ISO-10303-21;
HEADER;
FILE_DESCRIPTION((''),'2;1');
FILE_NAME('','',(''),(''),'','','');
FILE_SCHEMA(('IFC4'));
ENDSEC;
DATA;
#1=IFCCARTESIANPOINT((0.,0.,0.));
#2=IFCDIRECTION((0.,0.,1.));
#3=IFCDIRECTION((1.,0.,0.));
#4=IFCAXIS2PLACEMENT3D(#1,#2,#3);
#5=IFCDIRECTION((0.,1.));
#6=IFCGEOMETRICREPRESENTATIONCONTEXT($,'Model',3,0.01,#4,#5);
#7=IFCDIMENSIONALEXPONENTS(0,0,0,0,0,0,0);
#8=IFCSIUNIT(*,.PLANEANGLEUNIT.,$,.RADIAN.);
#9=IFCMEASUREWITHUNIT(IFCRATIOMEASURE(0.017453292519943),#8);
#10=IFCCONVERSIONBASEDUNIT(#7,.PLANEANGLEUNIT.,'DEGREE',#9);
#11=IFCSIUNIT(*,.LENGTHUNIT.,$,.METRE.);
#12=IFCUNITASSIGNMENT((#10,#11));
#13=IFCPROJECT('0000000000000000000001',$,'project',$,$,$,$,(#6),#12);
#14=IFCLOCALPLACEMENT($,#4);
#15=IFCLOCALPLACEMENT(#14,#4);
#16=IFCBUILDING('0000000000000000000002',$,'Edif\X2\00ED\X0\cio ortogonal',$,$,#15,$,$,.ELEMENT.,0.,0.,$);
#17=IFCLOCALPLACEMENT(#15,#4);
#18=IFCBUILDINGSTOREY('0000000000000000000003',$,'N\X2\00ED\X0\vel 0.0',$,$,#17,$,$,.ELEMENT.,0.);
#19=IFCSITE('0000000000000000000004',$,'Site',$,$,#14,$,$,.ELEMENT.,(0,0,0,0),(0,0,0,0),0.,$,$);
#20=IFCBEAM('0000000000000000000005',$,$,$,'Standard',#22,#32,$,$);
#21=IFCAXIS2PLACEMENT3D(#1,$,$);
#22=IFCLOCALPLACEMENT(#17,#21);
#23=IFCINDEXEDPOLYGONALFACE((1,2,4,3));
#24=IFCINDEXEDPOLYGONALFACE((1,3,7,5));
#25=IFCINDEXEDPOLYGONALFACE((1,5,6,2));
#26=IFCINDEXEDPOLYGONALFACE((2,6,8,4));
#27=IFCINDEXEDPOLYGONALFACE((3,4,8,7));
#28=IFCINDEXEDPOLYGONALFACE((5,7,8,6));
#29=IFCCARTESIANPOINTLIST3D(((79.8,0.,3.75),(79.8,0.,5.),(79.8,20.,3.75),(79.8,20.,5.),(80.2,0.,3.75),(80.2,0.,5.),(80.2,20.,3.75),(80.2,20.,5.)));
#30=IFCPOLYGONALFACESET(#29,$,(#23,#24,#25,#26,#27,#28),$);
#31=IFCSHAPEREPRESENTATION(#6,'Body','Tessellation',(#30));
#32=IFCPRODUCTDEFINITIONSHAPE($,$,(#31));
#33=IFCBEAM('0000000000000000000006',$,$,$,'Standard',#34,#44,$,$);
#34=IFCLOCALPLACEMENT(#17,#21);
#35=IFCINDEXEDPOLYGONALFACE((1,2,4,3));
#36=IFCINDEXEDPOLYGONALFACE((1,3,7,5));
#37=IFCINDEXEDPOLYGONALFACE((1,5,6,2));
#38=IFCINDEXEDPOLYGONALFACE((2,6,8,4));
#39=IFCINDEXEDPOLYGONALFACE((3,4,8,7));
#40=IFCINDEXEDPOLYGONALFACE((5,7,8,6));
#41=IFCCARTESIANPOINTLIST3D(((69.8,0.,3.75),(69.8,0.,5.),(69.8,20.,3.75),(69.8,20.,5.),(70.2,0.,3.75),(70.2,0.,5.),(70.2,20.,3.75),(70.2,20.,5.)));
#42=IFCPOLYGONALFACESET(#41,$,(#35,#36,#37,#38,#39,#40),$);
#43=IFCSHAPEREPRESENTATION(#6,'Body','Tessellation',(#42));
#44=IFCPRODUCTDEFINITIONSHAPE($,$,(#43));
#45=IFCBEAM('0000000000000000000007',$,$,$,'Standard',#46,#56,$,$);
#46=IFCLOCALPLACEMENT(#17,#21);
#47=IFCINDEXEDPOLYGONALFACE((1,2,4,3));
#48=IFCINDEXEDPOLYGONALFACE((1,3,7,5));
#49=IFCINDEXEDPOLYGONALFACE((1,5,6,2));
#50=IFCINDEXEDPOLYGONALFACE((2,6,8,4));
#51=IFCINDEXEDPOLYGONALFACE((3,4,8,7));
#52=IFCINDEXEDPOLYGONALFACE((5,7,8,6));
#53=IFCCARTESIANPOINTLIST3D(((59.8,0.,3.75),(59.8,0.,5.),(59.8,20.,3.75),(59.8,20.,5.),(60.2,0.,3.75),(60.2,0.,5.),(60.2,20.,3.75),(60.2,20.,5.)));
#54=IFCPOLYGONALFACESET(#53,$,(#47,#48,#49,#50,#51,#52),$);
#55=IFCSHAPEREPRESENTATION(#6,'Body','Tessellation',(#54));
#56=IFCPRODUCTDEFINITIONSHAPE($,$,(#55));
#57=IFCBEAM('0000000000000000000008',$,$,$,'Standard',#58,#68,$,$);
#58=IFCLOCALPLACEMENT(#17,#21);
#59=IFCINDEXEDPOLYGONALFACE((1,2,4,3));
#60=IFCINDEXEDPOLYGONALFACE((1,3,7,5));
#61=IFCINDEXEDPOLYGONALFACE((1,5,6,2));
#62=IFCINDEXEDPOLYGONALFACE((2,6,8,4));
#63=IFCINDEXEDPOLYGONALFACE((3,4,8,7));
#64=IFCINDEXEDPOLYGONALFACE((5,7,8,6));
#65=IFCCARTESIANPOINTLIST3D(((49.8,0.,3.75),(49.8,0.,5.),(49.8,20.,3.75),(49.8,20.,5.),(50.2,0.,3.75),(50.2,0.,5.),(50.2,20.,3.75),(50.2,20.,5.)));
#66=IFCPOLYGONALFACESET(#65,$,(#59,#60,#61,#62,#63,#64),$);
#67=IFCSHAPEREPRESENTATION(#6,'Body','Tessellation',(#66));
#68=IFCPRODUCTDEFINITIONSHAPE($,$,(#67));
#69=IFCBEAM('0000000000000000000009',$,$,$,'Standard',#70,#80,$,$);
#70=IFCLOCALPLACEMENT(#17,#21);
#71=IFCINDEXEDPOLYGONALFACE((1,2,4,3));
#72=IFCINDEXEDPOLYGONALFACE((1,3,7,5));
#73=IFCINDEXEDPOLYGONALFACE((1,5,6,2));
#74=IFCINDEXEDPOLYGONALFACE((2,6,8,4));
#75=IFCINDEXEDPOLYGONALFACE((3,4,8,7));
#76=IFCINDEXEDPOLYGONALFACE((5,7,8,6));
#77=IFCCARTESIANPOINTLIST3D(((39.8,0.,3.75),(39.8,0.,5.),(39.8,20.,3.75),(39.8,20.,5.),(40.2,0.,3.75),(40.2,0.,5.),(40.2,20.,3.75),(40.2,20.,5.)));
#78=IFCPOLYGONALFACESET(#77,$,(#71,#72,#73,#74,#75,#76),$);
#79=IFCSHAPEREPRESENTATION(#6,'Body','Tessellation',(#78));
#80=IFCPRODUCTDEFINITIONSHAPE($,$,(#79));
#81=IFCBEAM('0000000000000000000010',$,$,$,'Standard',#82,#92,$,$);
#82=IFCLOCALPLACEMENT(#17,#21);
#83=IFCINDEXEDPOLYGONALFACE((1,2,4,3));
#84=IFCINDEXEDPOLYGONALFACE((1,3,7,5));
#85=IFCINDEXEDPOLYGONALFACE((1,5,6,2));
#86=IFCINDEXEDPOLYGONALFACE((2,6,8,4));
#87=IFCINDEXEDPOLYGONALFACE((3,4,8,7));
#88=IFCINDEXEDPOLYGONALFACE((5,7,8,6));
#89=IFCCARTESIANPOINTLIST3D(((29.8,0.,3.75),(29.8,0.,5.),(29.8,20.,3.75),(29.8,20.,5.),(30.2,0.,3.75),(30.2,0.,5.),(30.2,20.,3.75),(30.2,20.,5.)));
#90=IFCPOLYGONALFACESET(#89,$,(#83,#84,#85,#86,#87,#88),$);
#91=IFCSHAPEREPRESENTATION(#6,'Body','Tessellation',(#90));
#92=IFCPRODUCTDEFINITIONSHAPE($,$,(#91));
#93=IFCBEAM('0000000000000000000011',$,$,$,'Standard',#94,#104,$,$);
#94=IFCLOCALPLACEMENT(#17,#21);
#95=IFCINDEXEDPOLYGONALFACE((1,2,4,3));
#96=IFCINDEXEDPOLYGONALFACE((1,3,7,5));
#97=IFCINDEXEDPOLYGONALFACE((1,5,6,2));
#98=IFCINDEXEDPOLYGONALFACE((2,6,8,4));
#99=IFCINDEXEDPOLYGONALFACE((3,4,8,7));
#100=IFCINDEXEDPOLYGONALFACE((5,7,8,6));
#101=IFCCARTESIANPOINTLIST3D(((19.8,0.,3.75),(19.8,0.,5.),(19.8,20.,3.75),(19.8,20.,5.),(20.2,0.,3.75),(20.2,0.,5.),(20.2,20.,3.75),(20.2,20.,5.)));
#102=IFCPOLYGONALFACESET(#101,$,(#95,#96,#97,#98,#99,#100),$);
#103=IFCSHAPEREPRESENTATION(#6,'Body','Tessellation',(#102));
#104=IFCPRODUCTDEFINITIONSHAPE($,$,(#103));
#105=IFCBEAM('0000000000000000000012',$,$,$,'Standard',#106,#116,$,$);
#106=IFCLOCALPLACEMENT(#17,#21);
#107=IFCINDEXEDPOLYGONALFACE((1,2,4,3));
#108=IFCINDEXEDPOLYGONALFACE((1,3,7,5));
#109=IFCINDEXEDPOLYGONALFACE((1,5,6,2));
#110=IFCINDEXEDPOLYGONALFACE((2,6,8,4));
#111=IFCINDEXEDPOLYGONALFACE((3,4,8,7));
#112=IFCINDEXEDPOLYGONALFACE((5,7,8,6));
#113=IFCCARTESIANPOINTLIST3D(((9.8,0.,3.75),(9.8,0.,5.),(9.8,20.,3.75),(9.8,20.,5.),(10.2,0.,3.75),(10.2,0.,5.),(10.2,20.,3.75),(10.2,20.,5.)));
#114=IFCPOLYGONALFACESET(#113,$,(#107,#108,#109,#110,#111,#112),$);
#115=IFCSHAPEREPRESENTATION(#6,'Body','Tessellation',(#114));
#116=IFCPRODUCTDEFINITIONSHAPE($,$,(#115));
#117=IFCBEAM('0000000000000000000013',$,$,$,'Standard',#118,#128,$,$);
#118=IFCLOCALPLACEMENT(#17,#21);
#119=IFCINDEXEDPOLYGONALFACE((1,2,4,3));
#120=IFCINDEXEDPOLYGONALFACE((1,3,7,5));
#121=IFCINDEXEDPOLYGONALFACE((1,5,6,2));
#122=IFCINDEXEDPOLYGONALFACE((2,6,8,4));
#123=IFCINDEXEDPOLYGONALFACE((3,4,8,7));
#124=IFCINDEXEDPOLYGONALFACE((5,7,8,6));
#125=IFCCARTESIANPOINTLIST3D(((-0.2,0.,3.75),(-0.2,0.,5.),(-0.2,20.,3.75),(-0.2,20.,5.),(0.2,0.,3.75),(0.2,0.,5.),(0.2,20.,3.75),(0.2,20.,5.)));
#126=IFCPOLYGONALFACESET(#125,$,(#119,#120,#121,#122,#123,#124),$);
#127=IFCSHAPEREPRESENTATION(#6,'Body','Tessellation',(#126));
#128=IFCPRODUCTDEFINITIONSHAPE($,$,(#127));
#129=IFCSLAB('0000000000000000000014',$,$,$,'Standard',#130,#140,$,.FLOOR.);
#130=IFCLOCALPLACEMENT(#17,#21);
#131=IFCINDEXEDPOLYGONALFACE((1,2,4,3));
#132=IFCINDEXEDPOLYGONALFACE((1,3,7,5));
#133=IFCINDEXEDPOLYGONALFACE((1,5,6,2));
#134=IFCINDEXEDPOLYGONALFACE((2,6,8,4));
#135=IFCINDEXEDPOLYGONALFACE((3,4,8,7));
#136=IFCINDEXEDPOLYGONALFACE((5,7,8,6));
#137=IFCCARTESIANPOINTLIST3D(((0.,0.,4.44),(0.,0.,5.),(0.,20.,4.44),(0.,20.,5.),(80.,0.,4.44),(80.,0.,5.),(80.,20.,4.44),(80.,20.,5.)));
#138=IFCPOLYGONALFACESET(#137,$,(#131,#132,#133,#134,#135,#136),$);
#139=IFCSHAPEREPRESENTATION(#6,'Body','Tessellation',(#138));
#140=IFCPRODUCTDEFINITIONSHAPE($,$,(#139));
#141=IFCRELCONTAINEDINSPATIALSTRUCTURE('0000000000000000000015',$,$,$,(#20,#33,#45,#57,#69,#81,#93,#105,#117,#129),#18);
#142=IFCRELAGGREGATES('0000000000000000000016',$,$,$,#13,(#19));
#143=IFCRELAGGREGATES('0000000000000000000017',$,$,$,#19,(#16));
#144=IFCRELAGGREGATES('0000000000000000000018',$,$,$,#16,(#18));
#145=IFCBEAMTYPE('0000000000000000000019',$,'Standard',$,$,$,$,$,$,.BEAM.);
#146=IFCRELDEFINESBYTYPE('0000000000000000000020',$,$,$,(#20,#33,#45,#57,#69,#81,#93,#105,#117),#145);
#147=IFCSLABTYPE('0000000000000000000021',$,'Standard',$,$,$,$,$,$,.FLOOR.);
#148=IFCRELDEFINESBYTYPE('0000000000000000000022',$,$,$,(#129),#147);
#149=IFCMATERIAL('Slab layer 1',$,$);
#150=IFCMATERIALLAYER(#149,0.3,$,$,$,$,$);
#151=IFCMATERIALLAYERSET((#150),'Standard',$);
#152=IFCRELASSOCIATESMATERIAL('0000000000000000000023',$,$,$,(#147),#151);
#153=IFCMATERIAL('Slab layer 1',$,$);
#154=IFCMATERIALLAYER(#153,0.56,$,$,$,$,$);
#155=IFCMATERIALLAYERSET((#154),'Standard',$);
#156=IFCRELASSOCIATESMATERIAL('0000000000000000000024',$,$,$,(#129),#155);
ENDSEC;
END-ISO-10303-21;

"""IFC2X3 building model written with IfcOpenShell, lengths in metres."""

from ifc_helpers import new_model, entity, si_unit, converted_unit, direction, frame, origin_with_axes, origin_2d, place, context, project, spatial, polyline, rectangle, outline, extrude, material, layer, layer_set, layer_usage, type_object, element, save


model = new_model("IFC2X3")

# Units and contexts
model_context = context("Model", 3, precision=0.01, world=origin_with_axes(), true_north=direction((0.0, 1.0)))
ifc_project = project(units=[converted_unit("PLANEANGLEUNIT", "DEGREE", entity("IfcRatioMeasure", 0.017453292519943), si_unit("PLANEANGLEUNIT", "RADIAN"), dimensions=[0, 0, 0, 0, 0, 0, 0]), si_unit("LENGTHUNIT", "METRE")], contexts=[model_context])

# Site, building, storey
site_placement = place(None, origin_with_axes())
site = spatial("IfcSite", under=ifc_project, at=site_placement, Name="Site", CompositionType="ELEMENT", RefLatitude=(0, 0, 0, 0), RefLongitude=(0, 0, 0, 0), RefElevation=0.0)
building_placement = place(site_placement, origin_with_axes())
building = spatial("IfcBuilding", under=site, at=building_placement, Name="Edifício ortogonal", CompositionType="ELEMENT", ElevationOfRefHeight=0.0, ElevationOfTerrain=0.0)
storey_placement = place(building_placement, origin_with_axes())
storey = spatial("IfcBuildingStorey", under=building, at=storey_placement, Name="Nível 0.0", CompositionType="ELEMENT", Elevation=0.0)

# Beams
beam_type = type_object("IfcBeamType", Name="Standard", PredefinedType="BEAM")
for number, where, z_axis, x_axis in (
    (1, (80.0, 20.0, 5.0), (0.0, 0.0, 1.0), (0.0, -1.0, 0.0)),
    (2, (70.0, 20.0, 5.0), (0.0, 0.0, 1.0), (0.0, -1.0, 0.0)),
    (3, (60.0, 20.0, 5.0), (0.0, 0.0, 1.0), (0.0, -1.0, 0.0)),
    (4, (50.0, 20.0, 5.0), (0.0, 0.0, 1.0), (0.0, -1.0, 0.0)),
    (5, (40.0, 20.0, 5.0), (0.0, 0.0, 1.0), (0.0, -1.0, 0.0)),
    (6, (30.0, 20.0, 5.0), (0.0, 0.0, 1.0), (0.0, -1.0, 0.0)),
    (7, (20.0, 20.0, 5.0), (0.0, 0.0, 1.0), (0.0, -1.0, 0.0)),
    (8, (10.0, 20.0, 5.0), (0.0, 0.0, 1.0), (0.0, -1.0, 0.0)),
    (9, (0.0, 20.0, 5.0), (0.0, 0.0, 1.0), (0.0, -1.0, 0.0)),
):
    element("IfcBeam", number, at=place(site_placement, frame(where, z_axis=z_axis, x_axis=x_axis)), inside=storey, type_object=beam_type, ObjectType="Standard", context=model_context, shape_type="SweptSolid", body=[
        extrude(rectangle(XDim=0.4, YDim=1.25, at=origin_2d()), frame((0.0, 0.0, -0.625), z_axis=(1.0, 0.0, 0.0), x_axis=(0.0, 1.0, 0.0)), (0.0, 0.0, 1.0), 20.0),
    ])

# Slab
ifc_material_1 = material(Name="Slab layer 1")
ifc_layer_1 = layer(ifc_material_1, 0.56)
ifc_layer_set_1 = layer_set([ifc_layer_1], Name="Standard")
ifc_layer_usage = layer_usage(ifc_layer_set_1, "AXIS3", "POSITIVE", 0.0)
ifc_material_2 = material(Name="Slab layer 1")
ifc_layer_2 = layer(ifc_material_2, 0.3)
ifc_layer_set_2 = layer_set([ifc_layer_2], Name="Standard")
slab_type = type_object("IfcSlabType", Name="Standard", PredefinedType="FLOOR", material=ifc_layer_set_2)
slab_placement = place(site_placement, frame((0.0, 0.0, 5.0), z_axis=(0.0, 0.0, 1.0), x_axis=(1.0, 0.0, 0.0)))
element("IfcSlab", 10, at=slab_placement, inside=storey, type_object=slab_type, material=ifc_layer_usage, ObjectType="Standard", PredefinedType="FLOOR", context=model_context, shape_type="SweptSolid", body=[
    extrude(outline(polyline([(0.0, 0.0), (80.0, 0.0), (80.0, 20.0), (0.0, 20.0), (0.0, 0.0)])), frame((0.0, 0.0, -0.56), z_axis=(0.0, 0.0, 1.0), x_axis=(1.0, 0.0, 0.0)), (0.0, 0.0, 1.0), 0.56),
])

save(model, "model.ifc")
